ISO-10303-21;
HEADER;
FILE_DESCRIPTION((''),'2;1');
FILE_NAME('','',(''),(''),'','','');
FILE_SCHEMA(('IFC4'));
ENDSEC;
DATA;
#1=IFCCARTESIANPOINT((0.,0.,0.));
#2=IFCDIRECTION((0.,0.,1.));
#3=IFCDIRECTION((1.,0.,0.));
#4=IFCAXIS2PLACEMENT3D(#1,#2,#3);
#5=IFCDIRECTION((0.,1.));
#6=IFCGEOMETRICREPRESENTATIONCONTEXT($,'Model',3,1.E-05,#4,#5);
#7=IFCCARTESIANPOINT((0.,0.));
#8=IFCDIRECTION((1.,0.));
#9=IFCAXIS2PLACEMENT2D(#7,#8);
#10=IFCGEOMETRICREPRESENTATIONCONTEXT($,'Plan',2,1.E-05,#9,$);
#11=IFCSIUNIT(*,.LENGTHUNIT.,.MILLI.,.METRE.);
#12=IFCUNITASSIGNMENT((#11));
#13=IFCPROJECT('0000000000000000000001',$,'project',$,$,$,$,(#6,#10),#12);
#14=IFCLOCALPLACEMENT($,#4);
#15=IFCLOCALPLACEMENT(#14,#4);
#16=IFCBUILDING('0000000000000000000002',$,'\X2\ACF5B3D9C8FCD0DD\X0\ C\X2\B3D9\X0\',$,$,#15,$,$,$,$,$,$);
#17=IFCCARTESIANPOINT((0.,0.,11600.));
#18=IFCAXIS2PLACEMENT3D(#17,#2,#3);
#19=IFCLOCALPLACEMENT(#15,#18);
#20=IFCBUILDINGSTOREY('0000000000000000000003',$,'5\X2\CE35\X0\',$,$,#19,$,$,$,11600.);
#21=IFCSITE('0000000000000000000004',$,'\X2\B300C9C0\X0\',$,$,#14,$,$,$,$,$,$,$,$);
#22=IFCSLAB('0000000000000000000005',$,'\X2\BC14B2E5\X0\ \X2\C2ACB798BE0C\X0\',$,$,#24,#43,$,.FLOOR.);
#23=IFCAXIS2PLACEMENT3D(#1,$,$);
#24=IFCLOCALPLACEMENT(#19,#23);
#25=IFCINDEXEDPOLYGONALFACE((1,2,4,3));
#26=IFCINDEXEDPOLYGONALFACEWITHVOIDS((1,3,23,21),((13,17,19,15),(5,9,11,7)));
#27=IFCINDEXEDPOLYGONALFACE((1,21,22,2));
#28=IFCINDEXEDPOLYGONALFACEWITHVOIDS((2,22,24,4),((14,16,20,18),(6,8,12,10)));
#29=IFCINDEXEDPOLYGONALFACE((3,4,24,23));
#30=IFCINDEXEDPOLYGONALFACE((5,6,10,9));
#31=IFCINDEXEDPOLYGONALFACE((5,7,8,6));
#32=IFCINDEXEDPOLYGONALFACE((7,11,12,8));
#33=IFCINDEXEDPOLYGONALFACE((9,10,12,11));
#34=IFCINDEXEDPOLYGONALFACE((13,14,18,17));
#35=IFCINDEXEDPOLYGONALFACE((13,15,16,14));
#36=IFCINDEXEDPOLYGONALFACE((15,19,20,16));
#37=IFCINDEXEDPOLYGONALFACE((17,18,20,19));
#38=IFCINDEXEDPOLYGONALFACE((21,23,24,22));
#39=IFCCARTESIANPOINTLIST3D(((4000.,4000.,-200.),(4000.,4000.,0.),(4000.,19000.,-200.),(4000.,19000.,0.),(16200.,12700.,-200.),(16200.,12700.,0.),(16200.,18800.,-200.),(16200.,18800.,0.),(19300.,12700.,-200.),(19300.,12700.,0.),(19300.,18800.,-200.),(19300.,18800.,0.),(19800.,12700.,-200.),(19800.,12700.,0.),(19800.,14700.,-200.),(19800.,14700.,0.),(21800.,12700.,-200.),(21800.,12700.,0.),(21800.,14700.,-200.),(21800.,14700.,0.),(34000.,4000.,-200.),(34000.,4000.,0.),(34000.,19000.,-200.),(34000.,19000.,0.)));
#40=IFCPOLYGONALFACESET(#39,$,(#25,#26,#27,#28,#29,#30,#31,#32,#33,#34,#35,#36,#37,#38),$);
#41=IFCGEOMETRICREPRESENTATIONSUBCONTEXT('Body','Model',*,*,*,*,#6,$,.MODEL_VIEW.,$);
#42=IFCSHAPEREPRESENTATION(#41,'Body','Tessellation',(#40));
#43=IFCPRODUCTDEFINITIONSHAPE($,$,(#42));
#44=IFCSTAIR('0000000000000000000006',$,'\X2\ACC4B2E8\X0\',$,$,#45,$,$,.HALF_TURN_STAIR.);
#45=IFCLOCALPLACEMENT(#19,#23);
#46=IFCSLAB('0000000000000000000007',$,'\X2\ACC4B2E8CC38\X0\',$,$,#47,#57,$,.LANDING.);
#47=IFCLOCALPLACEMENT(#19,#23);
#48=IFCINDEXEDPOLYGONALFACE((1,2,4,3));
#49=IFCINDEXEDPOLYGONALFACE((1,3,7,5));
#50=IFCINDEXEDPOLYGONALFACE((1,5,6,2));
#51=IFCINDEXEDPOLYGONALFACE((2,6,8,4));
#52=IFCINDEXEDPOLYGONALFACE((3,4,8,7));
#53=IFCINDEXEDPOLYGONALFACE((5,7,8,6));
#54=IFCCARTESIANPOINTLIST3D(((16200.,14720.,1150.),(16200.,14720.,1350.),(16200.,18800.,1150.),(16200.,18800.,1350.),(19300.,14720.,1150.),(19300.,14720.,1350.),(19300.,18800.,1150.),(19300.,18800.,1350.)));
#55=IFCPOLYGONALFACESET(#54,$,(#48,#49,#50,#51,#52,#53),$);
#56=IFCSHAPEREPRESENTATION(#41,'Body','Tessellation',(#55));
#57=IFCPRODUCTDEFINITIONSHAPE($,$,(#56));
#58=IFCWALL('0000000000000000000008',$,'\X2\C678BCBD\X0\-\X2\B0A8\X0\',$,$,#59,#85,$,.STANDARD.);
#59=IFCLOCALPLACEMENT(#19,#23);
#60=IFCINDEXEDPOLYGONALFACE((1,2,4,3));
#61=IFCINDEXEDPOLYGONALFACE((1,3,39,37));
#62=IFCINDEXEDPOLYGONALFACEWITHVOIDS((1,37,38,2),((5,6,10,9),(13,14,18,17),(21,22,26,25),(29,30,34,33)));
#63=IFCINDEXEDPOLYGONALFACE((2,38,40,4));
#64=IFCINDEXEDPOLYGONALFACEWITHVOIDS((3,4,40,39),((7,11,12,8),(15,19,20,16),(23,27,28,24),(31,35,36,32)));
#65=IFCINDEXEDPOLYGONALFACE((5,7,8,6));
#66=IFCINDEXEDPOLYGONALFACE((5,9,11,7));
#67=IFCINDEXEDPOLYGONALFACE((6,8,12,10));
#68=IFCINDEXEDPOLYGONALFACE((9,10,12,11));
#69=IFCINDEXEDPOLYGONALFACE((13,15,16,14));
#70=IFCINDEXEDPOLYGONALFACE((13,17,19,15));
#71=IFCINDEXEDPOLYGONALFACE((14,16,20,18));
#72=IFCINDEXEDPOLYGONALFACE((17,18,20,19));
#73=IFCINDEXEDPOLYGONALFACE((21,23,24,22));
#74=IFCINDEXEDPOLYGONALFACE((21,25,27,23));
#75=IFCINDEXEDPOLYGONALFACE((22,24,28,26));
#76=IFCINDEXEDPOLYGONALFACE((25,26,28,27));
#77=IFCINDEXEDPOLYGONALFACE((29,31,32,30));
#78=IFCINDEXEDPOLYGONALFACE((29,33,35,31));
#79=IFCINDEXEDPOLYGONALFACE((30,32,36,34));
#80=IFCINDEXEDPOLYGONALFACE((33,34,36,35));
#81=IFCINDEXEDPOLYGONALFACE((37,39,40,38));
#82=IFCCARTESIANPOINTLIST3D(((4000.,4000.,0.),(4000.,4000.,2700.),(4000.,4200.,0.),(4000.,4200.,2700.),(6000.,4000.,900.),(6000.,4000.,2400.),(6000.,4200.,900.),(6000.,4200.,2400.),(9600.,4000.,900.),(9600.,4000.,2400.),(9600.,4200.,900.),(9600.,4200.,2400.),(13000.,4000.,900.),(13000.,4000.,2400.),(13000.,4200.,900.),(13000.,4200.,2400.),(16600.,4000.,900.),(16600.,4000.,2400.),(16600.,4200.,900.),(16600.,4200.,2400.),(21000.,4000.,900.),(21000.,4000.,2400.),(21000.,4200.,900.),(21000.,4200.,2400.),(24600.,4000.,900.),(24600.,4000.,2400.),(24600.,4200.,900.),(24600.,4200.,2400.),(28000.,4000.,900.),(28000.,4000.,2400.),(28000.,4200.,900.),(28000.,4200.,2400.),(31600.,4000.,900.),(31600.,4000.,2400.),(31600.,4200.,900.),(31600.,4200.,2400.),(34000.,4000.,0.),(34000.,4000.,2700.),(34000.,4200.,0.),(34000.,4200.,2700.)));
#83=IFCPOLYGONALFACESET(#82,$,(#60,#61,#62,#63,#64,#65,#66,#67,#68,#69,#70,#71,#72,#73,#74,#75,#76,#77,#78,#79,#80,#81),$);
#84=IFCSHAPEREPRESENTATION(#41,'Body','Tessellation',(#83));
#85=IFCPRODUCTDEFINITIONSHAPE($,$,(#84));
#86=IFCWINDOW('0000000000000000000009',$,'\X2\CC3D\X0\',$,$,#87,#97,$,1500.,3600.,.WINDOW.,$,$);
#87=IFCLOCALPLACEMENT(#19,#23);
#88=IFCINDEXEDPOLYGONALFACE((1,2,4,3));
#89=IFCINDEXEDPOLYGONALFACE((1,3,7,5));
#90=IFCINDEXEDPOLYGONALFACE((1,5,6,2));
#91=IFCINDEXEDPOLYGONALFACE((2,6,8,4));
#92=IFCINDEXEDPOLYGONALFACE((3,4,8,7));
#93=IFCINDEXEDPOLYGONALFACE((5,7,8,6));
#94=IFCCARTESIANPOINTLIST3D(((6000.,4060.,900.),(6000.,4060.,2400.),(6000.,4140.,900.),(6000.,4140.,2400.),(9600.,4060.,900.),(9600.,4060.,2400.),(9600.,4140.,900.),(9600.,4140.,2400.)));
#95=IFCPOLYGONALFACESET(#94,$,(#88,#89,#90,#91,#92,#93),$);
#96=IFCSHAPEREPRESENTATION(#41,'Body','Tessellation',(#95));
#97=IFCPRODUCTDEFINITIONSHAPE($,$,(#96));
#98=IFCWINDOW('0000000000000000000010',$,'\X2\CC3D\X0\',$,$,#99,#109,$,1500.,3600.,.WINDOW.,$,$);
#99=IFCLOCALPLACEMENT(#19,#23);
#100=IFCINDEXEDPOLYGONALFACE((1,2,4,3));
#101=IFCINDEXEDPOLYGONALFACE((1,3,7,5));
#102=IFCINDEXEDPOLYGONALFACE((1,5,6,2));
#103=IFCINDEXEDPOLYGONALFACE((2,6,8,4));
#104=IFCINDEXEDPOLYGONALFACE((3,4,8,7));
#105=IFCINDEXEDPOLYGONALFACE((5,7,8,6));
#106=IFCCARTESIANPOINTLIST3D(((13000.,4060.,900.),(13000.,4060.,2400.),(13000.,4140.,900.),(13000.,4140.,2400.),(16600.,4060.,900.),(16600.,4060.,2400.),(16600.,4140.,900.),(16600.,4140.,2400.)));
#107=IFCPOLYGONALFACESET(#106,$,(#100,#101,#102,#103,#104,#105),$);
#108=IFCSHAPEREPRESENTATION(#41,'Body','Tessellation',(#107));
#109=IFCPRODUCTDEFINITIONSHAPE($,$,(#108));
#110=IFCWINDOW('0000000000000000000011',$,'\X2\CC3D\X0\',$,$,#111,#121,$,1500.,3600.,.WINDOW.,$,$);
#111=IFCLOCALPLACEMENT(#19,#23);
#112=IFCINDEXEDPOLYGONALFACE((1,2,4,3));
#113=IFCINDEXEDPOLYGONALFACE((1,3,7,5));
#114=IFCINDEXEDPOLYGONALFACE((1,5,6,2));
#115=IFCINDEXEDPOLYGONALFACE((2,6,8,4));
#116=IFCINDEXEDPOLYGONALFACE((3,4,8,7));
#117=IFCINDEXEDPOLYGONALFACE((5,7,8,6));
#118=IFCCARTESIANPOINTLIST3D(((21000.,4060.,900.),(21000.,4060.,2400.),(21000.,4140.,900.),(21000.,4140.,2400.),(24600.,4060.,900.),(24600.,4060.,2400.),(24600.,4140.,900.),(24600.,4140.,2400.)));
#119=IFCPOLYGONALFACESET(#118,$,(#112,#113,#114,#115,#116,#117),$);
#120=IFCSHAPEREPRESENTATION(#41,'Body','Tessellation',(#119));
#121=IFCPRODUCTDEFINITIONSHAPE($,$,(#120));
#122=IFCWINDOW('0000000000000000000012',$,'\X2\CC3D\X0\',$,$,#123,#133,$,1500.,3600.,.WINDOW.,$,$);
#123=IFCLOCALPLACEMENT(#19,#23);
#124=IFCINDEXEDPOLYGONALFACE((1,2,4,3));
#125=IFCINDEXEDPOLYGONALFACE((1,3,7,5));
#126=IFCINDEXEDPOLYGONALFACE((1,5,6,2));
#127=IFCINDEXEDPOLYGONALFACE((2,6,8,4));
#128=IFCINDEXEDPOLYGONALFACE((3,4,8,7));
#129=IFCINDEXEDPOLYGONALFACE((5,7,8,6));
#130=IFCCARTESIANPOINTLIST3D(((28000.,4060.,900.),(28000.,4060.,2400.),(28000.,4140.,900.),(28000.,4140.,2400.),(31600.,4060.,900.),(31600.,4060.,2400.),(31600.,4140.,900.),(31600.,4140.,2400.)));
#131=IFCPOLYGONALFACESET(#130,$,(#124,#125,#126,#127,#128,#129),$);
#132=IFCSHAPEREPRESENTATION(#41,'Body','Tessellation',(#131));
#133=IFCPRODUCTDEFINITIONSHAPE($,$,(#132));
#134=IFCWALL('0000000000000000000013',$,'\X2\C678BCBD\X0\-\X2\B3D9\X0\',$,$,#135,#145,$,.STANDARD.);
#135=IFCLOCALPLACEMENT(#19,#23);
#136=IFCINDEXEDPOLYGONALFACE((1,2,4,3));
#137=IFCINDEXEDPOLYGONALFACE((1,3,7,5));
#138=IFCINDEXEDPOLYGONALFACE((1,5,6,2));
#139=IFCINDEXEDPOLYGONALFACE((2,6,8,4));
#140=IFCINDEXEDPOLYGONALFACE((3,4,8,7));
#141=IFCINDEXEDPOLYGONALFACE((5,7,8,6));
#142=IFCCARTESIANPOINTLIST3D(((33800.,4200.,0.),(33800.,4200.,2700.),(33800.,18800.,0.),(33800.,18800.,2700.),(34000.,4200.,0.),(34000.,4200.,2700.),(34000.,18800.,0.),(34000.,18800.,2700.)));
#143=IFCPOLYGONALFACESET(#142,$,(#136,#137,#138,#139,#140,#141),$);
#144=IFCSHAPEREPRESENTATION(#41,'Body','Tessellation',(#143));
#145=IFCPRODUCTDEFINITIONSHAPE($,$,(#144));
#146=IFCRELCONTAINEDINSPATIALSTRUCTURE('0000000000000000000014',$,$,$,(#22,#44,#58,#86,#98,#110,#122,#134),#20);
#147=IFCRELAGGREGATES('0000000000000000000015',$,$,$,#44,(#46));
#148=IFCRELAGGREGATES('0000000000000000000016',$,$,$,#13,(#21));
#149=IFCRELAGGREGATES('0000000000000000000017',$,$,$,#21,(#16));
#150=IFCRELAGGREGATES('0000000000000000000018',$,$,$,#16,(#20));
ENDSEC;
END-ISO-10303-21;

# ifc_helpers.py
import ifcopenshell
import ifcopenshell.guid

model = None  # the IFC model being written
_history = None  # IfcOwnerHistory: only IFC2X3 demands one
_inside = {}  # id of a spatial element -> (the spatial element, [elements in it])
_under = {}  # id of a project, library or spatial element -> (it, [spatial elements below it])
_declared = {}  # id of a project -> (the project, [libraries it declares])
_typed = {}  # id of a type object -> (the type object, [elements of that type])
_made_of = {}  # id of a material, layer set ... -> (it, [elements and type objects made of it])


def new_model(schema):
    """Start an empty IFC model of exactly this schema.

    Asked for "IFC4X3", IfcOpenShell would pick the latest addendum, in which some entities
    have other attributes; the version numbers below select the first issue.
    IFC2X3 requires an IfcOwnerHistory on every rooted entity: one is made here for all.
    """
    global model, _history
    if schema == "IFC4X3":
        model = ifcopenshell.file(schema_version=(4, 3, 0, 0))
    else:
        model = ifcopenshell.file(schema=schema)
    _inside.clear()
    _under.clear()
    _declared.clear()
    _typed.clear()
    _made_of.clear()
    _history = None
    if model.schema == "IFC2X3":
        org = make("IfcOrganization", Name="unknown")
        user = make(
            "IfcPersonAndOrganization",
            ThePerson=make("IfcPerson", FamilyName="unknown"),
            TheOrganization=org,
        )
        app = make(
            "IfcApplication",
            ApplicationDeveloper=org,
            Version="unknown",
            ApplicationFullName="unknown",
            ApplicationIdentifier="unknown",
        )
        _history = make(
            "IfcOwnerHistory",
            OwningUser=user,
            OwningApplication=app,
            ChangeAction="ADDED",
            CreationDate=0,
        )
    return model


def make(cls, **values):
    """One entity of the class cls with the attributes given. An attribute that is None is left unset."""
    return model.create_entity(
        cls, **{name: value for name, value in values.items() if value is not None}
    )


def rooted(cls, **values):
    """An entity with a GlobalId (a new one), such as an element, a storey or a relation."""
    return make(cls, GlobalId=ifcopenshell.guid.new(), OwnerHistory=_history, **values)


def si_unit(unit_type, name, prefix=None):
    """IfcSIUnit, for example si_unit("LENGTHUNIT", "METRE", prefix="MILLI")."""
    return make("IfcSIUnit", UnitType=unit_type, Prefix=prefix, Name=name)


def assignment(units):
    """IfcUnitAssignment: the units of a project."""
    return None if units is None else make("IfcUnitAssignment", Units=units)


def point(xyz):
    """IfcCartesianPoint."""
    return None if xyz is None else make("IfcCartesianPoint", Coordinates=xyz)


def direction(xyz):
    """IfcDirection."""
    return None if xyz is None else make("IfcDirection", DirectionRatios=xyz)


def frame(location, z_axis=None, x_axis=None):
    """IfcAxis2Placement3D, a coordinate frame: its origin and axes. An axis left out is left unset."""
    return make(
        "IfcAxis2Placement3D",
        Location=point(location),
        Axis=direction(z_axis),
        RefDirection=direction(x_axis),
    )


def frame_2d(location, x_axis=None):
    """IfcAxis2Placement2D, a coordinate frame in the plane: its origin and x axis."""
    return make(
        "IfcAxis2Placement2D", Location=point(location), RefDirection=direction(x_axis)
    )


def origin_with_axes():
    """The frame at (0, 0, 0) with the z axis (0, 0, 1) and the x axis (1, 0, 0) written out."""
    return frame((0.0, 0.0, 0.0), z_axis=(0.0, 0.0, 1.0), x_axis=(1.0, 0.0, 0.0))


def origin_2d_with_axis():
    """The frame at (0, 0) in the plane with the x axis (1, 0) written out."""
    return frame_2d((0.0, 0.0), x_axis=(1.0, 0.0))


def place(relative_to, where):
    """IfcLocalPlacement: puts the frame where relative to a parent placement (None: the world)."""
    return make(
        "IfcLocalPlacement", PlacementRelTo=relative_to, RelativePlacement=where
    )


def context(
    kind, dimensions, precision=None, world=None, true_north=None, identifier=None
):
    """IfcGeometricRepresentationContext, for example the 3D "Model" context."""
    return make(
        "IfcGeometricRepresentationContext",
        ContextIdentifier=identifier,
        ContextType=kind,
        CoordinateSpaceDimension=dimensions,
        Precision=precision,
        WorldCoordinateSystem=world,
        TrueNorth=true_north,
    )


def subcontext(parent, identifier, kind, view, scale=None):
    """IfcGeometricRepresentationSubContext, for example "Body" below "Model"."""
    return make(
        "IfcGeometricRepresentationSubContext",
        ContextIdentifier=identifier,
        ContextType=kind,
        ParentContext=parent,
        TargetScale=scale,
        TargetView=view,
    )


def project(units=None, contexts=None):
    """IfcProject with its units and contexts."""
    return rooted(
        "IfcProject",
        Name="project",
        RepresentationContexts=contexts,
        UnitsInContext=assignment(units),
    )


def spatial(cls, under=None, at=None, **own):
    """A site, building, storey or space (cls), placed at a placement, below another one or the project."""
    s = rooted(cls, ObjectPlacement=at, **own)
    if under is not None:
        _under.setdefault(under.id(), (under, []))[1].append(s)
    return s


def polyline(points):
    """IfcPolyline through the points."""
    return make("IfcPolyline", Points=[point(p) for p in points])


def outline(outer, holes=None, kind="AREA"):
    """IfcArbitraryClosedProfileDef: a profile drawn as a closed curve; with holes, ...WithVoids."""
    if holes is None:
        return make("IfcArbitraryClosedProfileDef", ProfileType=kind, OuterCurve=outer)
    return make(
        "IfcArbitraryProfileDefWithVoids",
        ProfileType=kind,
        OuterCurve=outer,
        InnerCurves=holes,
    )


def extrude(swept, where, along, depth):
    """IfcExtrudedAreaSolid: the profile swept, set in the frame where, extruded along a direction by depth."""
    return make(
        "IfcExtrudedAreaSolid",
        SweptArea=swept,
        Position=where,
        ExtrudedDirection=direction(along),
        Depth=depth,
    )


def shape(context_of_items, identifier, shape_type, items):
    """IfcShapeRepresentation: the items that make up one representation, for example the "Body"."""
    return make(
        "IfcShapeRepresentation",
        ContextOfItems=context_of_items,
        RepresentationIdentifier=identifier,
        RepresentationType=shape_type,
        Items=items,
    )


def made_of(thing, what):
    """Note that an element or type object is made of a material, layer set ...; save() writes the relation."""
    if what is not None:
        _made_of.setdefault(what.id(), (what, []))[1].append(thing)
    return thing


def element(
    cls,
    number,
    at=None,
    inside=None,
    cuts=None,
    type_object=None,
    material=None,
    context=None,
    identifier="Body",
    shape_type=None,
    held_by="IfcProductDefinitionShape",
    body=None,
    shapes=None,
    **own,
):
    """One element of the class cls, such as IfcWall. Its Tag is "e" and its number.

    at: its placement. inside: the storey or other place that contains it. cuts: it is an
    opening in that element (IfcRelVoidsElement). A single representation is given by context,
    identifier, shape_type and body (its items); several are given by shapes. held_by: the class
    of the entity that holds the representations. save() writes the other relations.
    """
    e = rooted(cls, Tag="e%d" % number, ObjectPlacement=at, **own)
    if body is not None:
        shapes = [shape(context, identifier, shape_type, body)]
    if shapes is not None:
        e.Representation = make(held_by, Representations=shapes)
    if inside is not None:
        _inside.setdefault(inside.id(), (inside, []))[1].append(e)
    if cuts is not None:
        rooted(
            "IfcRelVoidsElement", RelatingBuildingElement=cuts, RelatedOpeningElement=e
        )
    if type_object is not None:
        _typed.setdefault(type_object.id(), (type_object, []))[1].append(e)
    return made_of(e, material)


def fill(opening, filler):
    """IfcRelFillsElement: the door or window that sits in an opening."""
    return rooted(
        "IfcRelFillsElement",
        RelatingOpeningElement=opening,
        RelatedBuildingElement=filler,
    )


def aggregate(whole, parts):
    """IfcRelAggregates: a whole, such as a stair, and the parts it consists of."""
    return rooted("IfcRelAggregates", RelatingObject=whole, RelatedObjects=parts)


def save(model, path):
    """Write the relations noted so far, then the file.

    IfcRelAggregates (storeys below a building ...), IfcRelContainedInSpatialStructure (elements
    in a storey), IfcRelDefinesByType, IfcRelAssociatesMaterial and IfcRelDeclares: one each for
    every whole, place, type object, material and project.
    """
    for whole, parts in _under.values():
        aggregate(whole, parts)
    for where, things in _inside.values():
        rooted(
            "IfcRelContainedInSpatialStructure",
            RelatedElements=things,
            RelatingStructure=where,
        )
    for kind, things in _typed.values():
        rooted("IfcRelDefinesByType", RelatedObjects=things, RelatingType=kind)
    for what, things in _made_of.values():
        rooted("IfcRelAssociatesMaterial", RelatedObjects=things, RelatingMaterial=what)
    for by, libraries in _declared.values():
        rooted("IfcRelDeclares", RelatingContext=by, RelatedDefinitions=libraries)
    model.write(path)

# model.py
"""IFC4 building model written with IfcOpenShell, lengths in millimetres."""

from ifc_helpers import new_model, si_unit, direction, frame, origin_with_axes, origin_2d_with_axis, place, context, subcontext, project, spatial, polyline, outline, extrude, element, fill, aggregate, save


model = new_model("IFC4")

# Units and contexts
model_context = context("Model", 3, precision=1e-05, world=origin_with_axes(), true_north=direction((0.0, 1.0)))
plan_context = context("Plan", 2, precision=1e-05, world=origin_2d_with_axis())
body_context = subcontext(model_context, "Body", "Model", "MODEL_VIEW")
ifc_project = project(units=[si_unit("LENGTHUNIT", "METRE", prefix="MILLI")], contexts=[model_context, plan_context])

# Site, building, storey
site_placement = place(None, origin_with_axes())
site = spatial("IfcSite", under=ifc_project, at=site_placement, Name="대지")
building_placement = place(site_placement, origin_with_axes())
building = spatial("IfcBuilding", under=site, at=building_placement, Name="공동주택 C동")
storey_placement = place(building_placement, frame((0.0, 0.0, 11600.0), z_axis=(0.0, 0.0, 1.0), x_axis=(1.0, 0.0, 0.0)))
storey = spatial("IfcBuildingStorey", under=building, at=storey_placement, Name="5층", Elevation=11600.0)

# Slab
slab_1_placement = place(storey_placement, origin_with_axes())
element("IfcSlab", 1, at=slab_1_placement, inside=storey, Name="바닥 슬래브", PredefinedType="FLOOR", context=body_context, shape_type="SweptSolid", body=[
    extrude(outline(polyline([(4000.0, 4000.0), (34000.0, 4000.0), (34000.0, 19000.0), (4000.0, 19000.0), (4000.0, 4000.0)]), holes=[polyline([(16200.0, 12700.0), (19300.0, 12700.0), (19300.0, 18800.0), (16200.0, 18800.0), (16200.0, 12700.0)]), polyline([(19800.0, 12700.0), (21800.0, 12700.0), (21800.0, 14700.0), (19800.0, 14700.0), (19800.0, 12700.0)])]), frame((0.0, 0.0, -200.0), z_axis=(0.0, 0.0, 1.0), x_axis=(1.0, 0.0, 0.0)), (0.0, 0.0, 1.0), 200.0),
])

# Stair, slab
stair_placement = place(storey_placement, origin_with_axes())
stair = element("IfcStair", 2, at=stair_placement, inside=storey, Name="계단", PredefinedType="HALF_TURN_STAIR")
slab_2_placement = place(stair_placement, origin_with_axes())
slab_2 = element("IfcSlab", 3, at=slab_2_placement, Name="계단참", PredefinedType="LANDING", context=body_context, shape_type="SweptSolid", body=[
    extrude(outline(polyline([(16200.0, 14720.0), (19300.0, 14720.0), (19300.0, 18800.0), (16200.0, 18800.0), (16200.0, 14720.0)])), frame((0.0, 0.0, 1150.0), z_axis=(0.0, 0.0, 1.0), x_axis=(1.0, 0.0, 0.0)), (0.0, 0.0, 1.0), 200.0),
])

# Wall, openings, windows
wall_1_placement = place(storey_placement, origin_with_axes())
wall_1 = element("IfcWall", 4, at=wall_1_placement, inside=storey, Name="외벽-남", PredefinedType="STANDARD", context=body_context, shape_type="SweptSolid", body=[
    extrude(outline(polyline([(4000.0, 4200.0), (34000.0, 4200.0), (34000.0, 4000.0), (4000.0, 4000.0), (4000.0, 4200.0)])), origin_with_axes(), (0.0, 0.0, 1.0), 2700.0),
])
opening_1_placement = place(storey_placement, origin_with_axes())
opening_1 = element("IfcOpeningElement", 5, at=opening_1_placement, cuts=wall_1, PredefinedType="OPENING", context=body_context, shape_type="SweptSolid", body=[
    extrude(outline(polyline([(6000.0, 3950.0), (9600.0, 3950.0), (9600.0, 4250.0), (6000.0, 4250.0), (6000.0, 3950.0)])), frame((0.0, 0.0, 900.0), z_axis=(0.0, 0.0, 1.0), x_axis=(1.0, 0.0, 0.0)), (0.0, 0.0, 1.0), 1500.0),
])
opening_2_placement = place(storey_placement, origin_with_axes())
opening_2 = element("IfcOpeningElement", 6, at=opening_2_placement, cuts=wall_1, PredefinedType="OPENING", context=body_context, shape_type="SweptSolid", body=[
    extrude(outline(polyline([(13000.0, 3950.0), (16600.0, 3950.0), (16600.0, 4250.0), (13000.0, 4250.0), (13000.0, 3950.0)])), frame((0.0, 0.0, 900.0), z_axis=(0.0, 0.0, 1.0), x_axis=(1.0, 0.0, 0.0)), (0.0, 0.0, 1.0), 1500.0),
])
opening_3_placement = place(storey_placement, origin_with_axes())
opening_3 = element("IfcOpeningElement", 7, at=opening_3_placement, cuts=wall_1, PredefinedType="OPENING", context=body_context, shape_type="SweptSolid", body=[
    extrude(outline(polyline([(21000.0, 3950.0), (24600.0, 3950.0), (24600.0, 4250.0), (21000.0, 4250.0), (21000.0, 3950.0)])), frame((0.0, 0.0, 900.0), z_axis=(0.0, 0.0, 1.0), x_axis=(1.0, 0.0, 0.0)), (0.0, 0.0, 1.0), 1500.0),
])
opening_4_placement = place(storey_placement, origin_with_axes())
opening_4 = element("IfcOpeningElement", 8, at=opening_4_placement, cuts=wall_1, PredefinedType="OPENING", context=body_context, shape_type="SweptSolid", body=[
    extrude(outline(polyline([(28000.0, 3950.0), (31600.0, 3950.0), (31600.0, 4250.0), (28000.0, 4250.0), (28000.0, 3950.0)])), frame((0.0, 0.0, 900.0), z_axis=(0.0, 0.0, 1.0), x_axis=(1.0, 0.0, 0.0)), (0.0, 0.0, 1.0), 1500.0),
])
window_1_placement = place(storey_placement, origin_with_axes())
window_1 = element("IfcWindow", 9, at=window_1_placement, inside=storey, Name="창", OverallHeight=1500.0, OverallWidth=3600.0, PredefinedType="WINDOW", context=body_context, shape_type="SweptSolid", body=[
    extrude(outline(polyline([(6000.0, 4060.0), (9600.0, 4060.0), (9600.0, 4140.0), (6000.0, 4140.0), (6000.0, 4060.0)])), frame((0.0, 0.0, 900.0), z_axis=(0.0, 0.0, 1.0), x_axis=(1.0, 0.0, 0.0)), (0.0, 0.0, 1.0), 1500.0),
])
fill(opening_1, window_1)
window_2_placement = place(storey_placement, origin_with_axes())
window_2 = element("IfcWindow", 10, at=window_2_placement, inside=storey, Name="창", OverallHeight=1500.0, OverallWidth=3600.0, PredefinedType="WINDOW", context=body_context, shape_type="SweptSolid", body=[
    extrude(outline(polyline([(13000.0, 4060.0), (16600.0, 4060.0), (16600.0, 4140.0), (13000.0, 4140.0), (13000.0, 4060.0)])), frame((0.0, 0.0, 900.0), z_axis=(0.0, 0.0, 1.0), x_axis=(1.0, 0.0, 0.0)), (0.0, 0.0, 1.0), 1500.0),
])
fill(opening_2, window_2)
window_3_placement = place(storey_placement, origin_with_axes())
window_3 = element("IfcWindow", 11, at=window_3_placement, inside=storey, Name="창", OverallHeight=1500.0, OverallWidth=3600.0, PredefinedType="WINDOW", context=body_context, shape_type="SweptSolid", body=[
    extrude(outline(polyline([(21000.0, 4060.0), (24600.0, 4060.0), (24600.0, 4140.0), (21000.0, 4140.0), (21000.0, 4060.0)])), frame((0.0, 0.0, 900.0), z_axis=(0.0, 0.0, 1.0), x_axis=(1.0, 0.0, 0.0)), (0.0, 0.0, 1.0), 1500.0),
])
fill(opening_3, window_3)
window_4_placement = place(storey_placement, origin_with_axes())
window_4 = element("IfcWindow", 12, at=window_4_placement, inside=storey, Name="창", OverallHeight=1500.0, OverallWidth=3600.0, PredefinedType="WINDOW", context=body_context, shape_type="SweptSolid", body=[
    extrude(outline(polyline([(28000.0, 4060.0), (31600.0, 4060.0), (31600.0, 4140.0), (28000.0, 4140.0), (28000.0, 4060.0)])), frame((0.0, 0.0, 900.0), z_axis=(0.0, 0.0, 1.0), x_axis=(1.0, 0.0, 0.0)), (0.0, 0.0, 1.0), 1500.0),
])
fill(opening_4, window_4)

# Wall
wall_2_placement = place(storey_placement, origin_with_axes())
element("IfcWall", 13, at=wall_2_placement, inside=storey, Name="외벽-동", PredefinedType="STANDARD", context=body_context, shape_type="SweptSolid", body=[
    extrude(outline(polyline([(33800.0, 4200.0), (33800.0, 18800.0), (34000.0, 18800.0), (34000.0, 4200.0), (33800.0, 4200.0)])), origin_with_axes(), (0.0, 0.0, 1.0), 2700.0),
])

aggregate(stair, [slab_2])

save(model, "model.ifc")
